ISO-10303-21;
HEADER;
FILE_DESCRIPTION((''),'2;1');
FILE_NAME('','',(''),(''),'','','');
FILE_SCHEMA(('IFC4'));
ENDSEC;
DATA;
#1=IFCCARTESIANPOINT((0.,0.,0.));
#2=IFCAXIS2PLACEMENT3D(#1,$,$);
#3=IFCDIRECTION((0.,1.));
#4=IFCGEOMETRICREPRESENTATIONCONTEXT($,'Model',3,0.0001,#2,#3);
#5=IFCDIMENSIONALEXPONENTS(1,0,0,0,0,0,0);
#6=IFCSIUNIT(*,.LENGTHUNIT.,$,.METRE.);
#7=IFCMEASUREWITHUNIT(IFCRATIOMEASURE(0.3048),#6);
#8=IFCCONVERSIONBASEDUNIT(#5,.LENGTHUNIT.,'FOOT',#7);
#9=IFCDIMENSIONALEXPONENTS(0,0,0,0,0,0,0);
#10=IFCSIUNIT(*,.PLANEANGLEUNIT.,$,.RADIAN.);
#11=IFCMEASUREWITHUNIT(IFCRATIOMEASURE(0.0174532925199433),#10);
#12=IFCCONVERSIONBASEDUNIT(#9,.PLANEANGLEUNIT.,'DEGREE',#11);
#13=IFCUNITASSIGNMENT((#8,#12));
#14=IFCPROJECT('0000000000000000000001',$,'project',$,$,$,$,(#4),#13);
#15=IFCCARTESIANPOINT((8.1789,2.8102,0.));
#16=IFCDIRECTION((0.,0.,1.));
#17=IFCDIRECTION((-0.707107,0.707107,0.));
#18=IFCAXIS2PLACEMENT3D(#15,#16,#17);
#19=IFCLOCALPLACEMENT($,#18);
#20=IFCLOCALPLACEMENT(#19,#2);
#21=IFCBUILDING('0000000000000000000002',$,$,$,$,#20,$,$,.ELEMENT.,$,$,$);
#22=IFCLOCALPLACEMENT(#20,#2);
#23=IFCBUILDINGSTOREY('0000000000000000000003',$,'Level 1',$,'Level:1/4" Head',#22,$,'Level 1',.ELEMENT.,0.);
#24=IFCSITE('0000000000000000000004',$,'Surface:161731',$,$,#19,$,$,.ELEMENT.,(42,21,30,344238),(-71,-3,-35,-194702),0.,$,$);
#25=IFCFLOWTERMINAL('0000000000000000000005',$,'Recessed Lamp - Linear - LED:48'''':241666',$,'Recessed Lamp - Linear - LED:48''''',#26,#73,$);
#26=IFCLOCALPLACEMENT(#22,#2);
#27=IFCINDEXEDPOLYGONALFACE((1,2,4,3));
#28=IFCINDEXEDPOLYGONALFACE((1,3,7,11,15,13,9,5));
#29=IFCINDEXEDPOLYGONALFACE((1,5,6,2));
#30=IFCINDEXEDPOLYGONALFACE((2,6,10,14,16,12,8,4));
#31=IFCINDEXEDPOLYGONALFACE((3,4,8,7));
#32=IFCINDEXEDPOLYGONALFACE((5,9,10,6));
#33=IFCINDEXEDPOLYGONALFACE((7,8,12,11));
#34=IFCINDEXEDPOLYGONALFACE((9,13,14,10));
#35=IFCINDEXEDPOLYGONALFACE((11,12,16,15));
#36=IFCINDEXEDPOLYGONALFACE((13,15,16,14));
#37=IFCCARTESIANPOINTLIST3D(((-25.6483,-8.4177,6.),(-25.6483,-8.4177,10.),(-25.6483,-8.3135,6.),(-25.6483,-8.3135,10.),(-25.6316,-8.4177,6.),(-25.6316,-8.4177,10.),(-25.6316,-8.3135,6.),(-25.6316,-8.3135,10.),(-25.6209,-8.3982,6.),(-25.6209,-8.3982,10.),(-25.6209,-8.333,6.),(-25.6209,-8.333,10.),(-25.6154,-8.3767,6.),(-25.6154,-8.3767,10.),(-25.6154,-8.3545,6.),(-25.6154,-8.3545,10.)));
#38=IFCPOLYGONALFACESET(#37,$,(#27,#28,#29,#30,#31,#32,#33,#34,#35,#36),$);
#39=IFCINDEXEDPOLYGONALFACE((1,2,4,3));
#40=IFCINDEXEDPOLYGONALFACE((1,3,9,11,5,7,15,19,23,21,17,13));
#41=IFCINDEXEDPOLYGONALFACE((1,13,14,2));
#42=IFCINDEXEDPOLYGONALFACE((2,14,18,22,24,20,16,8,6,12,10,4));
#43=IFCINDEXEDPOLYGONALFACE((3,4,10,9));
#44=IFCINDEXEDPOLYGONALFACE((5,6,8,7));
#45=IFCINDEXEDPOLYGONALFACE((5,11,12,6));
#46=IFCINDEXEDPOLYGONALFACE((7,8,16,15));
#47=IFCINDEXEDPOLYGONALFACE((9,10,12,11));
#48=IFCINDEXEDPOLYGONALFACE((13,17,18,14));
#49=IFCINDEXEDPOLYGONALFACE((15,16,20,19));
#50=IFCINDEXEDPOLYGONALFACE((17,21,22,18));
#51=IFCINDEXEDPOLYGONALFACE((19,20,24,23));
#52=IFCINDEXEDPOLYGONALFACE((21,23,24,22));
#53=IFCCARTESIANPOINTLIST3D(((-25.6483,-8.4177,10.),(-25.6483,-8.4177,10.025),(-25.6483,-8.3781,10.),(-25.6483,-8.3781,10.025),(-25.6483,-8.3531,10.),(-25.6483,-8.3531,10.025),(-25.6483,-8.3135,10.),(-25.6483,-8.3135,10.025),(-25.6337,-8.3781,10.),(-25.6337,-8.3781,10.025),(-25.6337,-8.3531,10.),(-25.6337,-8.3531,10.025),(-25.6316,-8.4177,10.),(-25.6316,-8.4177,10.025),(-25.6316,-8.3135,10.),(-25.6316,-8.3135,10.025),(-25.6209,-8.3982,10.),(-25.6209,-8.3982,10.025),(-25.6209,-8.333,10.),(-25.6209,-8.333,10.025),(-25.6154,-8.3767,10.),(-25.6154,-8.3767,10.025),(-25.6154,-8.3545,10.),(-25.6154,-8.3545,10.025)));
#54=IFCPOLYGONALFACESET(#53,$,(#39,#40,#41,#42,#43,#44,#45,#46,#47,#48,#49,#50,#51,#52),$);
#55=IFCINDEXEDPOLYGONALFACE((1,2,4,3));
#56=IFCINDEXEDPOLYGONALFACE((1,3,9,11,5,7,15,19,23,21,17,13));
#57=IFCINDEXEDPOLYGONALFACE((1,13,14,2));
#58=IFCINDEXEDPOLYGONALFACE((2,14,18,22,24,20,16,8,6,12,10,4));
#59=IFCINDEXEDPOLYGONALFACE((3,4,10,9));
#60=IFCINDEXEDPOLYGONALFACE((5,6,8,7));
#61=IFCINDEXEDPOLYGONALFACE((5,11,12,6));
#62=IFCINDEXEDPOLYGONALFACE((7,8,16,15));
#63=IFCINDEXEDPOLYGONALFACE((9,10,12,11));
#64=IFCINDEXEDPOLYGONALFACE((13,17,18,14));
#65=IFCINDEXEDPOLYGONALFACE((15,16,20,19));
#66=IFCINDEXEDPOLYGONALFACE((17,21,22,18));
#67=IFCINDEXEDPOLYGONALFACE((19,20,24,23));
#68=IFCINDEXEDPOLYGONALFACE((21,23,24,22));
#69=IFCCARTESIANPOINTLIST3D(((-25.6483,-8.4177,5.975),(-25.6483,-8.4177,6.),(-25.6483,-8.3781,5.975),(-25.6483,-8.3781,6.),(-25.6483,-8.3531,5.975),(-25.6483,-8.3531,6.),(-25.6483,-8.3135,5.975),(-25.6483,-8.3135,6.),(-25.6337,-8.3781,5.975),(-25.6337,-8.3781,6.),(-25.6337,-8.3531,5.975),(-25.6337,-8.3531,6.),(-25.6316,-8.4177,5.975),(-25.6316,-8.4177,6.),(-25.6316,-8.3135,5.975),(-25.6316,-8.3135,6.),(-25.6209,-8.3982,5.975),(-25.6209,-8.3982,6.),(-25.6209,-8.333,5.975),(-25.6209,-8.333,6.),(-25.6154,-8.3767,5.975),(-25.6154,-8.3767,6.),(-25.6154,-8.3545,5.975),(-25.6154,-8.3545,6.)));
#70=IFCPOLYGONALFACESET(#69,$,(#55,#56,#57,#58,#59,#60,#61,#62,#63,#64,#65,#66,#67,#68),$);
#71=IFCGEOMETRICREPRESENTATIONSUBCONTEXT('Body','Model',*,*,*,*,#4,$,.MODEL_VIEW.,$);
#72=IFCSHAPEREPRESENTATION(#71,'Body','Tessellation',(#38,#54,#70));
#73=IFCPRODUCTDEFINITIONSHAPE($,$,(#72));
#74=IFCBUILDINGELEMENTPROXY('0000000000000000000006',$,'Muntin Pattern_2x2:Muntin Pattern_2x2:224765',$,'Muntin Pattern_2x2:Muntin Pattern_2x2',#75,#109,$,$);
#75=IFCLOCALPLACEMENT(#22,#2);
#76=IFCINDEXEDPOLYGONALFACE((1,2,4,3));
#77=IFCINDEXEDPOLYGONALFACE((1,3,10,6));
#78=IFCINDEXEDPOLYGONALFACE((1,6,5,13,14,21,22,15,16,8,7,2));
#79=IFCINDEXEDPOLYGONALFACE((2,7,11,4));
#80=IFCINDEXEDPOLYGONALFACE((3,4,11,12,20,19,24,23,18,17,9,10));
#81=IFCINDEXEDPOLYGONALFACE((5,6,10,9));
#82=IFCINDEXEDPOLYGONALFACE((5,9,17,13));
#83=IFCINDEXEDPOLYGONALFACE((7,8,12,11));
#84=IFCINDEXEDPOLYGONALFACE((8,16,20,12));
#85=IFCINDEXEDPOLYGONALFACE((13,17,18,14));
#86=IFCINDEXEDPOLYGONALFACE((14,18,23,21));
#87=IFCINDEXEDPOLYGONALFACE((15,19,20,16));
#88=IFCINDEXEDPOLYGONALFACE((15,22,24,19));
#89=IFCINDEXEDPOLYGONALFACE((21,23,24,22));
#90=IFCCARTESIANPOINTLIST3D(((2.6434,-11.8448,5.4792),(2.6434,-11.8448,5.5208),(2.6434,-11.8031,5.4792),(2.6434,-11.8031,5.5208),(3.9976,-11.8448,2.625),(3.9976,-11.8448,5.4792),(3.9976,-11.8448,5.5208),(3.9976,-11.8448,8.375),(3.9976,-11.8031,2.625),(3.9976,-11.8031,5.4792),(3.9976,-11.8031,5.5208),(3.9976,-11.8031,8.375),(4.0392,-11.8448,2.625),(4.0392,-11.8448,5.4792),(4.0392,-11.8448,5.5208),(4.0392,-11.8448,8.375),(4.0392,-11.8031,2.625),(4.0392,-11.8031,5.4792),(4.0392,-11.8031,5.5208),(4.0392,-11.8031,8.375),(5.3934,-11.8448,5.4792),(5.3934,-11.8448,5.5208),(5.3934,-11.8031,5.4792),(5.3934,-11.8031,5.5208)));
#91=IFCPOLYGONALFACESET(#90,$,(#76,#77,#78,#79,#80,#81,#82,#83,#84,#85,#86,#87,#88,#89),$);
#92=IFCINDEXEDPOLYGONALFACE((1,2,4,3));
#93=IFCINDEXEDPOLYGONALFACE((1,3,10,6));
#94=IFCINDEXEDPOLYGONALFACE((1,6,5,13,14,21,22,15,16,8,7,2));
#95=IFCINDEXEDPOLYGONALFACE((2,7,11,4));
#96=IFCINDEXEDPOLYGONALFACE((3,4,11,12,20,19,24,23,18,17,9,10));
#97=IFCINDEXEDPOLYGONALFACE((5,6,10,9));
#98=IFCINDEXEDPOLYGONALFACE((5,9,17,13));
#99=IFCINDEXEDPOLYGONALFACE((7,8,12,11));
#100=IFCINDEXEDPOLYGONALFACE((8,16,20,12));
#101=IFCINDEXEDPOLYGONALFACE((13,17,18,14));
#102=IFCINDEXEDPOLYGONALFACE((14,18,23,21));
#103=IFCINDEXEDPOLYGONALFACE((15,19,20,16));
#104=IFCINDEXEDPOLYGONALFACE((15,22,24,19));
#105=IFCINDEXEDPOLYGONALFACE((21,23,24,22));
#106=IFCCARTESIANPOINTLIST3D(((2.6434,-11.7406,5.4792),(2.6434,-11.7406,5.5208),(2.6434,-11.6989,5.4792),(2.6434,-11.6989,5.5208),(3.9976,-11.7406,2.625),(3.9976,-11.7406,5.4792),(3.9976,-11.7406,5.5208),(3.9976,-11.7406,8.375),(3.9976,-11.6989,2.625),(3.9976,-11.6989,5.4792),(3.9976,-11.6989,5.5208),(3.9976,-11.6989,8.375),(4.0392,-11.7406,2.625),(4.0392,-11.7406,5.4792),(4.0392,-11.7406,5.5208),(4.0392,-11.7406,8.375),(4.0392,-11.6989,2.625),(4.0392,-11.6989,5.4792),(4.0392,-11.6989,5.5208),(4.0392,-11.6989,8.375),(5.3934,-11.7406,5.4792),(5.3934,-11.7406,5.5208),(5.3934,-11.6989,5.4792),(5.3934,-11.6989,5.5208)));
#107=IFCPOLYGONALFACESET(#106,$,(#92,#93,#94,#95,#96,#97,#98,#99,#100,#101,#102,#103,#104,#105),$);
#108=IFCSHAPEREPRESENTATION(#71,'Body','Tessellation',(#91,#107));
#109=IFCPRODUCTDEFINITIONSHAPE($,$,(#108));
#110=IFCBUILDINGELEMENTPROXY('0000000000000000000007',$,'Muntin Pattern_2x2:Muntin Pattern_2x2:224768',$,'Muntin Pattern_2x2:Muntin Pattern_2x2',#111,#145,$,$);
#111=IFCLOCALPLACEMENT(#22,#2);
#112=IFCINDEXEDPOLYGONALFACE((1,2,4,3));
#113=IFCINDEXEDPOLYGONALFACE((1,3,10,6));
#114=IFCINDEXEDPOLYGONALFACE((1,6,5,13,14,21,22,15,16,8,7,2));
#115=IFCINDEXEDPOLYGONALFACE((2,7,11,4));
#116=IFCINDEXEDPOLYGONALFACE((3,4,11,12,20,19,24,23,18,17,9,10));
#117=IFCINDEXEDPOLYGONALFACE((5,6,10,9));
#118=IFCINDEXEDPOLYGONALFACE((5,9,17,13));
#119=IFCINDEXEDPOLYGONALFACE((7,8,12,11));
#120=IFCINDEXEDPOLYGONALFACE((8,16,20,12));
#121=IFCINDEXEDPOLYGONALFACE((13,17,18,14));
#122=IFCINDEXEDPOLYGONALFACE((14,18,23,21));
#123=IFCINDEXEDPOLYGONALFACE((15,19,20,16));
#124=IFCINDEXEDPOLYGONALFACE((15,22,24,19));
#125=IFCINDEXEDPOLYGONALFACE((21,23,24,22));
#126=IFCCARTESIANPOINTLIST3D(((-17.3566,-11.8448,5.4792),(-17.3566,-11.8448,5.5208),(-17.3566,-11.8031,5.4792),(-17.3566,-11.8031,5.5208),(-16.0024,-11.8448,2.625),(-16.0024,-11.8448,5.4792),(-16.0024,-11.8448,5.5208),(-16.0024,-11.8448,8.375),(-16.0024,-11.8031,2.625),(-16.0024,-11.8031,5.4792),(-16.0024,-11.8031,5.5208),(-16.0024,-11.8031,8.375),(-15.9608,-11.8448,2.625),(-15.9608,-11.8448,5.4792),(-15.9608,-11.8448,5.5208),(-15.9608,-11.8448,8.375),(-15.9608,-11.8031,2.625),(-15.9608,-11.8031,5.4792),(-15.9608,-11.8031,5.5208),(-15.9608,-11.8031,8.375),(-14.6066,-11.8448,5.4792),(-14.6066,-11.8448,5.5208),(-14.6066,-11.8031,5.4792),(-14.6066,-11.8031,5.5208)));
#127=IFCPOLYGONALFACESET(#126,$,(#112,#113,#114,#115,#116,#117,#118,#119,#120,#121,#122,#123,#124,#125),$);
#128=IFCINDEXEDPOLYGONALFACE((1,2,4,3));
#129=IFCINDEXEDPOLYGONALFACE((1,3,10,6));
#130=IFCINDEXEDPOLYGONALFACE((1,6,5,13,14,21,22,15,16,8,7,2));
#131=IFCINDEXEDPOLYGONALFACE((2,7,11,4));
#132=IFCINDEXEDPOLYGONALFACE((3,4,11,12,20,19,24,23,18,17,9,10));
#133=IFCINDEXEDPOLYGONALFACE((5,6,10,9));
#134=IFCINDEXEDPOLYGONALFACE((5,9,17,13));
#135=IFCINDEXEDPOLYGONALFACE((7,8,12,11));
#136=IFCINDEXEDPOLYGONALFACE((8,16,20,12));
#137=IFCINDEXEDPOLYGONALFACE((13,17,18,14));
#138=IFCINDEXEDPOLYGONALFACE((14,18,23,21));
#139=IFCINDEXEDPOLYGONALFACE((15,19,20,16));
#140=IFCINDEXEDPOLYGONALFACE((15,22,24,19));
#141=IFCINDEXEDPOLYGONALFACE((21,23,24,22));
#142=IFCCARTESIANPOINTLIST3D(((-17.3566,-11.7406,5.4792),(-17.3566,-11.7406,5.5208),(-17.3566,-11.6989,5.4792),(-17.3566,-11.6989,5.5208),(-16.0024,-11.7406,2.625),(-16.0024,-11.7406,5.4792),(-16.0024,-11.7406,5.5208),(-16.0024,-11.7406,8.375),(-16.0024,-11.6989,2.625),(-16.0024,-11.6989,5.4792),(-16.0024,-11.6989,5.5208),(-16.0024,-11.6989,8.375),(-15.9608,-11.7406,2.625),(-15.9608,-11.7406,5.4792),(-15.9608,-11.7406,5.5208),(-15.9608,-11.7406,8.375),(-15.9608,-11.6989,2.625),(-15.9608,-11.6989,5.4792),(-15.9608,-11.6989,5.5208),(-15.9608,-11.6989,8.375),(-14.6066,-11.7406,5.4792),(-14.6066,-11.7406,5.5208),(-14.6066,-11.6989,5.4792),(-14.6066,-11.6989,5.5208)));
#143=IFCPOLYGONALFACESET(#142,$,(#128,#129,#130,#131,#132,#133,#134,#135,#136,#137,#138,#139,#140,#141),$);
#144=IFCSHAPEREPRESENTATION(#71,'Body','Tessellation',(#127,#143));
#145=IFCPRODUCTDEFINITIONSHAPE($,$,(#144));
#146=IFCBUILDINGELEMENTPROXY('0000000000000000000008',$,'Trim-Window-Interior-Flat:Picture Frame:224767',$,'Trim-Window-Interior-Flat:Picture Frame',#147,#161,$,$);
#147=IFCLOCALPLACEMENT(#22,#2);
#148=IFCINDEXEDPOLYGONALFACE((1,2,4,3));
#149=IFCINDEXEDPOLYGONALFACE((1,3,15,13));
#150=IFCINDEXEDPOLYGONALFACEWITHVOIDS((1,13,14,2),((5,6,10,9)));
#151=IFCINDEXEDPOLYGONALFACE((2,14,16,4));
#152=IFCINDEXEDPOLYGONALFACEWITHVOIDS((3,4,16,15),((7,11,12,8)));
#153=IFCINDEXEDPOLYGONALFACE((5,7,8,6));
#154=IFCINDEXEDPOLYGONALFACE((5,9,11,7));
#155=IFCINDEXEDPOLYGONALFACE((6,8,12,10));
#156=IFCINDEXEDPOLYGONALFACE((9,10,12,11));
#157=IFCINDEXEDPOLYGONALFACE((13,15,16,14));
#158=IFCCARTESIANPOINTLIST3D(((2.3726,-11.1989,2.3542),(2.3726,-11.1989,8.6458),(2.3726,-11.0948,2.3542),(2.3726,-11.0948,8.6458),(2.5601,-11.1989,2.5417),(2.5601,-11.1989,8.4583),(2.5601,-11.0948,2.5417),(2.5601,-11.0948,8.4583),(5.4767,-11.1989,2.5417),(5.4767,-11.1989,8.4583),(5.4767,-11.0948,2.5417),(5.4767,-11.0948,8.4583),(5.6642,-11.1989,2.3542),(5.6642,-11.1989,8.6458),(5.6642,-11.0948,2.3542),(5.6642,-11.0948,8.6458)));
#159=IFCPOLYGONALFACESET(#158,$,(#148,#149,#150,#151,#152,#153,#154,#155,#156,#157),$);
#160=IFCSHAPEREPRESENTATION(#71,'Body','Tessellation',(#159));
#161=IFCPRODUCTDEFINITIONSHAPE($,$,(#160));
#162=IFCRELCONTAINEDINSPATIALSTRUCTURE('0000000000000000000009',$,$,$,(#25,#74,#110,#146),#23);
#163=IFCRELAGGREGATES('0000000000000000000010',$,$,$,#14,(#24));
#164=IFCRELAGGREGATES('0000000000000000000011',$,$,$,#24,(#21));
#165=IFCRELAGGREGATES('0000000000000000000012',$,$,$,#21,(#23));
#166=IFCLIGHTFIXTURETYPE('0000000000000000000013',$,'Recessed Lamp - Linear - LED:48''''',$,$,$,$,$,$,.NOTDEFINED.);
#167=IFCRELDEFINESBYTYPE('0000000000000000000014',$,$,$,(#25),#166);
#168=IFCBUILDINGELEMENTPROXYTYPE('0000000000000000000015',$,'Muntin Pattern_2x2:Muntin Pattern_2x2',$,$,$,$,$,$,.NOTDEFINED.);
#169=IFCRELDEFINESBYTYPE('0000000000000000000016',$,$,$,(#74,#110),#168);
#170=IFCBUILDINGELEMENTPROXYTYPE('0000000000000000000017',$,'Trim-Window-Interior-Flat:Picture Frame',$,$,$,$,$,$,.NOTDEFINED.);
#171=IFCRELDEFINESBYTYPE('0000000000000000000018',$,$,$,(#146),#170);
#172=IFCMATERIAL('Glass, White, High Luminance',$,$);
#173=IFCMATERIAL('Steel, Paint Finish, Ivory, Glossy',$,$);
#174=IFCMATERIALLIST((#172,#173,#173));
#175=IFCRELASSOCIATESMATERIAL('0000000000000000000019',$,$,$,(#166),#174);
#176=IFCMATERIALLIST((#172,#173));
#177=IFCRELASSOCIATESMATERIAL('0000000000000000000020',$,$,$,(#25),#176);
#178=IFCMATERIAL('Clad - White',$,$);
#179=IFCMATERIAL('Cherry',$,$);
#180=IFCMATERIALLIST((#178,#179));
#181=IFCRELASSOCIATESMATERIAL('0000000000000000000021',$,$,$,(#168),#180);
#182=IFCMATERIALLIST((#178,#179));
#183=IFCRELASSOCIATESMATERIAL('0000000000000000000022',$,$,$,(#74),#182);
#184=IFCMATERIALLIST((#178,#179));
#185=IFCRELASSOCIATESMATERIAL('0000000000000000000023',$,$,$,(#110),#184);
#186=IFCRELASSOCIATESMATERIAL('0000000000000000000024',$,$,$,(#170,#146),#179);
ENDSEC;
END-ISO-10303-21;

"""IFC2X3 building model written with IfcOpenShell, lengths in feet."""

from ifc_helpers import new_model, entity, si_unit, converted_unit, direction, frame, frame_2d, origin, place, context, subcontext, project, spatial, polyline, circle_curve, parameter, trimmed, segment, composite_curve, outline, extrude, source, transform, mapped, material, material_list, type_object, type_shapes, element, save


model = new_model("IFC2X3")

# Units and contexts
model_context = context("Model", 3, precision=0.0001, world=origin(), true_north=direction((0.0, 1.0)))
body_context = subcontext(model_context, "Body", "Model", "MODEL_VIEW")
ifc_project = project(units=[converted_unit("LENGTHUNIT", "FOOT", entity("IfcRatioMeasure", 0.3048), si_unit("LENGTHUNIT", "METRE"), dimensions=[1, 0, 0, 0, 0, 0, 0]), converted_unit("PLANEANGLEUNIT", "DEGREE", entity("IfcRatioMeasure", 0.0174532925199433), si_unit("PLANEANGLEUNIT", "RADIAN"), dimensions=[0, 0, 0, 0, 0, 0, 0])], contexts=[model_context])

# Site, building, storey
site_placement = place(None, frame((8.1789, 2.8102, 0.0), z_axis=(0.0, 0.0, 1.0), x_axis=(-0.707107, 0.707107, 0.0)))
site = spatial("IfcSite", under=ifc_project, at=site_placement, Name="Surface:161731", CompositionType="ELEMENT", RefLatitude=(42, 21, 30, 344238), RefLongitude=(-71, -3, -35, -194702), RefElevation=0.0)
building_placement = place(site_placement, origin())
building = spatial("IfcBuilding", under=site, at=building_placement, CompositionType="ELEMENT")
storey_placement = place(building_placement, origin())
storey = spatial("IfcBuildingStorey", under=building, at=storey_placement, Name="Level 1", ObjectType="Level:1/4\" Head", LongName="Level 1", CompositionType="ELEMENT", Elevation=0.0)

# Flow terminal
ifc_material_1 = material(Name="Glass, White, High Luminance")
ifc_material_2 = material(Name="Steel, Paint Finish, Ivory, Glossy")
ifc_material_list_1 = material_list([ifc_material_1, ifc_material_2])
ifc_material_list_2 = material_list([ifc_material_1, ifc_material_2, ifc_material_2])
light_fixture_type_1 = type_object("IfcLightFixtureType", Name="Recessed Lamp - Linear - LED:48''", PredefinedType="NOTDEFINED", material=ifc_material_list_2)
shared_shape_1 = source(origin(), body_context, "Body", "SweptSolid", [
    extrude(outline(composite_curve([segment(trimmed(circle_curve(frame_2d((0.0, -0.0639), x_axis=(1.0, 0.0)), 0.089), [parameter(54.196986)], [parameter(125.803014)], True, "PARAMETER"), True, "CONTINUOUS"), segment(polyline([(-0.0521, 0.0083), (-0.0521, -0.0083)]), True, "CONTINUOUS"), segment(polyline([(-0.0521, -0.0083), (0.0521, -0.0083)]), True, "CONTINUOUS"), segment(polyline([(0.0521, -0.0083), (0.0521, 0.0083)]), True, "CONTINUOUS")], self_intersect=False)), frame((-2.0, 0.0, 0.0083), z_axis=(1.0, 0.0, 0.0), x_axis=(0.0, 1.0, 0.0)), (0.0, 0.0, 1.0), 4.0),
    extrude(outline(composite_curve([segment(trimmed(circle_curve(frame_2d((0.0, -0.0633), x_axis=(1.0, 0.0)), 0.089), [parameter(54.196986)], [parameter(125.803014)], True, "PARAMETER"), True, "CONTINUOUS"), segment(polyline([(-0.0521, 0.0089), (-0.0521, -0.0078)]), True, "CONTINUOUS"), segment(polyline([(-0.0521, -0.0078), (-0.0125, -0.0078)]), True, "CONTINUOUS"), segment(polyline([(-0.0125, -0.0078), (-0.0125, 0.0068)]), True, "CONTINUOUS"), segment(polyline([(-0.0125, 0.0068), (0.0125, 0.0068)]), True, "CONTINUOUS"), segment(polyline([(0.0125, 0.0068), (0.0125, -0.0078)]), True, "CONTINUOUS"), segment(polyline([(0.0125, -0.0078), (0.0521, -0.0078)]), True, "CONTINUOUS"), segment(polyline([(0.0521, -0.0078), (0.0521, 0.0089)]), True, "CONTINUOUS")], self_intersect=False)), frame((2.0, 0.0, 0.0078), z_axis=(1.0, 0.0, 0.0), x_axis=(0.0, 1.0, 0.0)), (0.0, 0.0, 1.0), 0.025),
    extrude(outline(composite_curve([segment(trimmed(circle_curve(frame_2d((0.0, -0.0633), x_axis=(1.0, 0.0)), 0.089), [parameter(54.196986)], [parameter(125.803014)], True, "PARAMETER"), True, "CONTINUOUS"), segment(polyline([(-0.0521, 0.0089), (-0.0521, -0.0078)]), True, "CONTINUOUS"), segment(polyline([(-0.0521, -0.0078), (-0.0125, -0.0078)]), True, "CONTINUOUS"), segment(polyline([(-0.0125, -0.0078), (-0.0125, 0.0068)]), True, "CONTINUOUS"), segment(polyline([(-0.0125, 0.0068), (0.0125, 0.0068)]), True, "CONTINUOUS"), segment(polyline([(0.0125, 0.0068), (0.0125, -0.0078)]), True, "CONTINUOUS"), segment(polyline([(0.0125, -0.0078), (0.0521, -0.0078)]), True, "CONTINUOUS"), segment(polyline([(0.0521, -0.0078), (0.0521, 0.0089)]), True, "CONTINUOUS")], self_intersect=False)), frame((-2.025, 0.0, 0.0078), z_axis=(1.0, 0.0, 0.0), x_axis=(0.0, 1.0, 0.0)), (0.0, 0.0, 1.0), 0.025),
])
type_shapes(light_fixture_type_1, [shared_shape_1])
flow_terminal_1_placement = place(storey_placement, frame((-25.6483, -8.3656, 8.0), z_axis=(1.0, 0.0, 0.0), x_axis=(0.0, 0.0, 1.0)))
element("IfcFlowTerminal", 1, at=flow_terminal_1_placement, inside=storey, type_object=light_fixture_type_1, material=ifc_material_list_1, Name="Recessed Lamp - Linear - LED:48'':241666", ObjectType="Recessed Lamp - Linear - LED:48''", context=body_context, shape_type="MappedRepresentation", body=[
    mapped(shared_shape_1, transform((0.0, 0.0, 0.0), scale=1.0)),
])

# Building element proxies
ifc_material_3 = material(Name="Clad - White")
ifc_material_4 = material(Name="Cherry")
ifc_material_list_3 = material_list([ifc_material_3, ifc_material_4])
ifc_material_list_4 = material_list([ifc_material_3, ifc_material_4])
building_element_proxy_type_1 = type_object("IfcBuildingElementProxyType", Name="Muntin Pattern_2x2:Muntin Pattern_2x2", PredefinedType="NOTDEFINED", material=ifc_material_list_4)
shared_shape_2 = source(origin(), body_context, "Body", "SweptSolid", [
    extrude(outline(polyline([(0.0208, -0.0208), (2.875, -0.0208), (2.875, 0.0208), (0.0208, 0.0208), (0.0208, 1.375), (-0.0208, 1.375), (-0.0208, 0.0208), (-2.875, 0.0208), (-2.875, -0.0208), (-0.0208, -0.0208), (-0.0208, -1.375), (0.0208, -1.375), (0.0208, -0.0208)])), frame((0.0, -0.0729, 2.875), z_axis=(0.0, 1.0, 0.0), x_axis=(0.0, 0.0, 1.0)), (0.0, 0.0, 1.0), 0.0417),
    extrude(outline(polyline([(0.0208, -0.0208), (2.875, -0.0208), (2.875, 0.0208), (0.0208, 0.0208), (0.0208, 1.375), (-0.0208, 1.375), (-0.0208, 0.0208), (-2.875, 0.0208), (-2.875, -0.0208), (-0.0208, -0.0208), (-0.0208, -1.375), (0.0208, -1.375), (0.0208, -0.0208)])), frame((0.0, 0.0313, 2.875), z_axis=(0.0, 1.0, 0.0), x_axis=(0.0, 0.0, 1.0)), (0.0, 0.0, 1.0), 0.0417),
])
type_shapes(building_element_proxy_type_1, [shared_shape_2])
proxy_1_placement = place(storey_placement, frame((4.0184, -11.7719, 2.625)))
element("IfcBuildingElementProxy", 2, at=proxy_1_placement, inside=storey, type_object=building_element_proxy_type_1, material=ifc_material_list_3, Name="Muntin Pattern_2x2:Muntin Pattern_2x2:224765", ObjectType="Muntin Pattern_2x2:Muntin Pattern_2x2", context=body_context, shape_type="MappedRepresentation", body=[
    mapped(shared_shape_2, transform((0.0, 0.0, 0.0), scale=1.0)),
])
ifc_material_list_5 = material_list([ifc_material_3, ifc_material_4])
proxy_2_placement = place(storey_placement, frame((-15.9816, -11.7719, 2.625)))
element("IfcBuildingElementProxy", 3, at=proxy_2_placement, inside=storey, type_object=building_element_proxy_type_1, material=ifc_material_list_5, Name="Muntin Pattern_2x2:Muntin Pattern_2x2:224768", ObjectType="Muntin Pattern_2x2:Muntin Pattern_2x2", context=body_context, shape_type="MappedRepresentation", body=[
    mapped(shared_shape_2, transform((0.0, 0.0, 0.0), scale=1.0)),
])
building_element_proxy_type_2 = type_object("IfcBuildingElementProxyType", Name="Trim-Window-Interior-Flat:Picture Frame", PredefinedType="NOTDEFINED", material=ifc_material_4)
shared_shape_3 = source(origin(), body_context, "Body", "SweptSolid", [
    extrude(outline(polyline([(-1.6458, -3.1458), (1.6458, -3.1458), (1.6458, 3.1458), (-1.6458, 3.1458), (-1.6458, -3.1458)]), holes=[polyline([(-1.4583, -2.9583), (-1.4583, 2.9583), (1.4583, 2.9583), (1.4583, -2.9583), (-1.4583, -2.9583)])]), frame((0.0, -3.0, 0.0), z_axis=(0.0, 0.0, 1.0), x_axis=(-1.0, 0.0, 0.0)), (0.0, 0.0, 1.0), 0.1042),
])
type_shapes(building_element_proxy_type_2, [shared_shape_3])
for number, where, z_axis, x_axis, name in (
    (4, (4.0184, -11.1989, 8.5), (0.0, 1.0, 0.0), (-1.0, 0.0, 0.0), "Trim-Window-Interior-Flat:Picture Frame:224767"),
):
    element("IfcBuildingElementProxy", number, at=place(storey_placement, frame(where, z_axis=z_axis, x_axis=x_axis)), inside=storey, type_object=building_element_proxy_type_2, material=ifc_material_4, Name=name, ObjectType="Trim-Window-Interior-Flat:Picture Frame", context=body_context, shape_type="MappedRepresentation", body=[
        mapped(shared_shape_3, transform((0.0, 0.0, 0.0), scale=1.0)),
    ])

save(model, "model.ifc")
